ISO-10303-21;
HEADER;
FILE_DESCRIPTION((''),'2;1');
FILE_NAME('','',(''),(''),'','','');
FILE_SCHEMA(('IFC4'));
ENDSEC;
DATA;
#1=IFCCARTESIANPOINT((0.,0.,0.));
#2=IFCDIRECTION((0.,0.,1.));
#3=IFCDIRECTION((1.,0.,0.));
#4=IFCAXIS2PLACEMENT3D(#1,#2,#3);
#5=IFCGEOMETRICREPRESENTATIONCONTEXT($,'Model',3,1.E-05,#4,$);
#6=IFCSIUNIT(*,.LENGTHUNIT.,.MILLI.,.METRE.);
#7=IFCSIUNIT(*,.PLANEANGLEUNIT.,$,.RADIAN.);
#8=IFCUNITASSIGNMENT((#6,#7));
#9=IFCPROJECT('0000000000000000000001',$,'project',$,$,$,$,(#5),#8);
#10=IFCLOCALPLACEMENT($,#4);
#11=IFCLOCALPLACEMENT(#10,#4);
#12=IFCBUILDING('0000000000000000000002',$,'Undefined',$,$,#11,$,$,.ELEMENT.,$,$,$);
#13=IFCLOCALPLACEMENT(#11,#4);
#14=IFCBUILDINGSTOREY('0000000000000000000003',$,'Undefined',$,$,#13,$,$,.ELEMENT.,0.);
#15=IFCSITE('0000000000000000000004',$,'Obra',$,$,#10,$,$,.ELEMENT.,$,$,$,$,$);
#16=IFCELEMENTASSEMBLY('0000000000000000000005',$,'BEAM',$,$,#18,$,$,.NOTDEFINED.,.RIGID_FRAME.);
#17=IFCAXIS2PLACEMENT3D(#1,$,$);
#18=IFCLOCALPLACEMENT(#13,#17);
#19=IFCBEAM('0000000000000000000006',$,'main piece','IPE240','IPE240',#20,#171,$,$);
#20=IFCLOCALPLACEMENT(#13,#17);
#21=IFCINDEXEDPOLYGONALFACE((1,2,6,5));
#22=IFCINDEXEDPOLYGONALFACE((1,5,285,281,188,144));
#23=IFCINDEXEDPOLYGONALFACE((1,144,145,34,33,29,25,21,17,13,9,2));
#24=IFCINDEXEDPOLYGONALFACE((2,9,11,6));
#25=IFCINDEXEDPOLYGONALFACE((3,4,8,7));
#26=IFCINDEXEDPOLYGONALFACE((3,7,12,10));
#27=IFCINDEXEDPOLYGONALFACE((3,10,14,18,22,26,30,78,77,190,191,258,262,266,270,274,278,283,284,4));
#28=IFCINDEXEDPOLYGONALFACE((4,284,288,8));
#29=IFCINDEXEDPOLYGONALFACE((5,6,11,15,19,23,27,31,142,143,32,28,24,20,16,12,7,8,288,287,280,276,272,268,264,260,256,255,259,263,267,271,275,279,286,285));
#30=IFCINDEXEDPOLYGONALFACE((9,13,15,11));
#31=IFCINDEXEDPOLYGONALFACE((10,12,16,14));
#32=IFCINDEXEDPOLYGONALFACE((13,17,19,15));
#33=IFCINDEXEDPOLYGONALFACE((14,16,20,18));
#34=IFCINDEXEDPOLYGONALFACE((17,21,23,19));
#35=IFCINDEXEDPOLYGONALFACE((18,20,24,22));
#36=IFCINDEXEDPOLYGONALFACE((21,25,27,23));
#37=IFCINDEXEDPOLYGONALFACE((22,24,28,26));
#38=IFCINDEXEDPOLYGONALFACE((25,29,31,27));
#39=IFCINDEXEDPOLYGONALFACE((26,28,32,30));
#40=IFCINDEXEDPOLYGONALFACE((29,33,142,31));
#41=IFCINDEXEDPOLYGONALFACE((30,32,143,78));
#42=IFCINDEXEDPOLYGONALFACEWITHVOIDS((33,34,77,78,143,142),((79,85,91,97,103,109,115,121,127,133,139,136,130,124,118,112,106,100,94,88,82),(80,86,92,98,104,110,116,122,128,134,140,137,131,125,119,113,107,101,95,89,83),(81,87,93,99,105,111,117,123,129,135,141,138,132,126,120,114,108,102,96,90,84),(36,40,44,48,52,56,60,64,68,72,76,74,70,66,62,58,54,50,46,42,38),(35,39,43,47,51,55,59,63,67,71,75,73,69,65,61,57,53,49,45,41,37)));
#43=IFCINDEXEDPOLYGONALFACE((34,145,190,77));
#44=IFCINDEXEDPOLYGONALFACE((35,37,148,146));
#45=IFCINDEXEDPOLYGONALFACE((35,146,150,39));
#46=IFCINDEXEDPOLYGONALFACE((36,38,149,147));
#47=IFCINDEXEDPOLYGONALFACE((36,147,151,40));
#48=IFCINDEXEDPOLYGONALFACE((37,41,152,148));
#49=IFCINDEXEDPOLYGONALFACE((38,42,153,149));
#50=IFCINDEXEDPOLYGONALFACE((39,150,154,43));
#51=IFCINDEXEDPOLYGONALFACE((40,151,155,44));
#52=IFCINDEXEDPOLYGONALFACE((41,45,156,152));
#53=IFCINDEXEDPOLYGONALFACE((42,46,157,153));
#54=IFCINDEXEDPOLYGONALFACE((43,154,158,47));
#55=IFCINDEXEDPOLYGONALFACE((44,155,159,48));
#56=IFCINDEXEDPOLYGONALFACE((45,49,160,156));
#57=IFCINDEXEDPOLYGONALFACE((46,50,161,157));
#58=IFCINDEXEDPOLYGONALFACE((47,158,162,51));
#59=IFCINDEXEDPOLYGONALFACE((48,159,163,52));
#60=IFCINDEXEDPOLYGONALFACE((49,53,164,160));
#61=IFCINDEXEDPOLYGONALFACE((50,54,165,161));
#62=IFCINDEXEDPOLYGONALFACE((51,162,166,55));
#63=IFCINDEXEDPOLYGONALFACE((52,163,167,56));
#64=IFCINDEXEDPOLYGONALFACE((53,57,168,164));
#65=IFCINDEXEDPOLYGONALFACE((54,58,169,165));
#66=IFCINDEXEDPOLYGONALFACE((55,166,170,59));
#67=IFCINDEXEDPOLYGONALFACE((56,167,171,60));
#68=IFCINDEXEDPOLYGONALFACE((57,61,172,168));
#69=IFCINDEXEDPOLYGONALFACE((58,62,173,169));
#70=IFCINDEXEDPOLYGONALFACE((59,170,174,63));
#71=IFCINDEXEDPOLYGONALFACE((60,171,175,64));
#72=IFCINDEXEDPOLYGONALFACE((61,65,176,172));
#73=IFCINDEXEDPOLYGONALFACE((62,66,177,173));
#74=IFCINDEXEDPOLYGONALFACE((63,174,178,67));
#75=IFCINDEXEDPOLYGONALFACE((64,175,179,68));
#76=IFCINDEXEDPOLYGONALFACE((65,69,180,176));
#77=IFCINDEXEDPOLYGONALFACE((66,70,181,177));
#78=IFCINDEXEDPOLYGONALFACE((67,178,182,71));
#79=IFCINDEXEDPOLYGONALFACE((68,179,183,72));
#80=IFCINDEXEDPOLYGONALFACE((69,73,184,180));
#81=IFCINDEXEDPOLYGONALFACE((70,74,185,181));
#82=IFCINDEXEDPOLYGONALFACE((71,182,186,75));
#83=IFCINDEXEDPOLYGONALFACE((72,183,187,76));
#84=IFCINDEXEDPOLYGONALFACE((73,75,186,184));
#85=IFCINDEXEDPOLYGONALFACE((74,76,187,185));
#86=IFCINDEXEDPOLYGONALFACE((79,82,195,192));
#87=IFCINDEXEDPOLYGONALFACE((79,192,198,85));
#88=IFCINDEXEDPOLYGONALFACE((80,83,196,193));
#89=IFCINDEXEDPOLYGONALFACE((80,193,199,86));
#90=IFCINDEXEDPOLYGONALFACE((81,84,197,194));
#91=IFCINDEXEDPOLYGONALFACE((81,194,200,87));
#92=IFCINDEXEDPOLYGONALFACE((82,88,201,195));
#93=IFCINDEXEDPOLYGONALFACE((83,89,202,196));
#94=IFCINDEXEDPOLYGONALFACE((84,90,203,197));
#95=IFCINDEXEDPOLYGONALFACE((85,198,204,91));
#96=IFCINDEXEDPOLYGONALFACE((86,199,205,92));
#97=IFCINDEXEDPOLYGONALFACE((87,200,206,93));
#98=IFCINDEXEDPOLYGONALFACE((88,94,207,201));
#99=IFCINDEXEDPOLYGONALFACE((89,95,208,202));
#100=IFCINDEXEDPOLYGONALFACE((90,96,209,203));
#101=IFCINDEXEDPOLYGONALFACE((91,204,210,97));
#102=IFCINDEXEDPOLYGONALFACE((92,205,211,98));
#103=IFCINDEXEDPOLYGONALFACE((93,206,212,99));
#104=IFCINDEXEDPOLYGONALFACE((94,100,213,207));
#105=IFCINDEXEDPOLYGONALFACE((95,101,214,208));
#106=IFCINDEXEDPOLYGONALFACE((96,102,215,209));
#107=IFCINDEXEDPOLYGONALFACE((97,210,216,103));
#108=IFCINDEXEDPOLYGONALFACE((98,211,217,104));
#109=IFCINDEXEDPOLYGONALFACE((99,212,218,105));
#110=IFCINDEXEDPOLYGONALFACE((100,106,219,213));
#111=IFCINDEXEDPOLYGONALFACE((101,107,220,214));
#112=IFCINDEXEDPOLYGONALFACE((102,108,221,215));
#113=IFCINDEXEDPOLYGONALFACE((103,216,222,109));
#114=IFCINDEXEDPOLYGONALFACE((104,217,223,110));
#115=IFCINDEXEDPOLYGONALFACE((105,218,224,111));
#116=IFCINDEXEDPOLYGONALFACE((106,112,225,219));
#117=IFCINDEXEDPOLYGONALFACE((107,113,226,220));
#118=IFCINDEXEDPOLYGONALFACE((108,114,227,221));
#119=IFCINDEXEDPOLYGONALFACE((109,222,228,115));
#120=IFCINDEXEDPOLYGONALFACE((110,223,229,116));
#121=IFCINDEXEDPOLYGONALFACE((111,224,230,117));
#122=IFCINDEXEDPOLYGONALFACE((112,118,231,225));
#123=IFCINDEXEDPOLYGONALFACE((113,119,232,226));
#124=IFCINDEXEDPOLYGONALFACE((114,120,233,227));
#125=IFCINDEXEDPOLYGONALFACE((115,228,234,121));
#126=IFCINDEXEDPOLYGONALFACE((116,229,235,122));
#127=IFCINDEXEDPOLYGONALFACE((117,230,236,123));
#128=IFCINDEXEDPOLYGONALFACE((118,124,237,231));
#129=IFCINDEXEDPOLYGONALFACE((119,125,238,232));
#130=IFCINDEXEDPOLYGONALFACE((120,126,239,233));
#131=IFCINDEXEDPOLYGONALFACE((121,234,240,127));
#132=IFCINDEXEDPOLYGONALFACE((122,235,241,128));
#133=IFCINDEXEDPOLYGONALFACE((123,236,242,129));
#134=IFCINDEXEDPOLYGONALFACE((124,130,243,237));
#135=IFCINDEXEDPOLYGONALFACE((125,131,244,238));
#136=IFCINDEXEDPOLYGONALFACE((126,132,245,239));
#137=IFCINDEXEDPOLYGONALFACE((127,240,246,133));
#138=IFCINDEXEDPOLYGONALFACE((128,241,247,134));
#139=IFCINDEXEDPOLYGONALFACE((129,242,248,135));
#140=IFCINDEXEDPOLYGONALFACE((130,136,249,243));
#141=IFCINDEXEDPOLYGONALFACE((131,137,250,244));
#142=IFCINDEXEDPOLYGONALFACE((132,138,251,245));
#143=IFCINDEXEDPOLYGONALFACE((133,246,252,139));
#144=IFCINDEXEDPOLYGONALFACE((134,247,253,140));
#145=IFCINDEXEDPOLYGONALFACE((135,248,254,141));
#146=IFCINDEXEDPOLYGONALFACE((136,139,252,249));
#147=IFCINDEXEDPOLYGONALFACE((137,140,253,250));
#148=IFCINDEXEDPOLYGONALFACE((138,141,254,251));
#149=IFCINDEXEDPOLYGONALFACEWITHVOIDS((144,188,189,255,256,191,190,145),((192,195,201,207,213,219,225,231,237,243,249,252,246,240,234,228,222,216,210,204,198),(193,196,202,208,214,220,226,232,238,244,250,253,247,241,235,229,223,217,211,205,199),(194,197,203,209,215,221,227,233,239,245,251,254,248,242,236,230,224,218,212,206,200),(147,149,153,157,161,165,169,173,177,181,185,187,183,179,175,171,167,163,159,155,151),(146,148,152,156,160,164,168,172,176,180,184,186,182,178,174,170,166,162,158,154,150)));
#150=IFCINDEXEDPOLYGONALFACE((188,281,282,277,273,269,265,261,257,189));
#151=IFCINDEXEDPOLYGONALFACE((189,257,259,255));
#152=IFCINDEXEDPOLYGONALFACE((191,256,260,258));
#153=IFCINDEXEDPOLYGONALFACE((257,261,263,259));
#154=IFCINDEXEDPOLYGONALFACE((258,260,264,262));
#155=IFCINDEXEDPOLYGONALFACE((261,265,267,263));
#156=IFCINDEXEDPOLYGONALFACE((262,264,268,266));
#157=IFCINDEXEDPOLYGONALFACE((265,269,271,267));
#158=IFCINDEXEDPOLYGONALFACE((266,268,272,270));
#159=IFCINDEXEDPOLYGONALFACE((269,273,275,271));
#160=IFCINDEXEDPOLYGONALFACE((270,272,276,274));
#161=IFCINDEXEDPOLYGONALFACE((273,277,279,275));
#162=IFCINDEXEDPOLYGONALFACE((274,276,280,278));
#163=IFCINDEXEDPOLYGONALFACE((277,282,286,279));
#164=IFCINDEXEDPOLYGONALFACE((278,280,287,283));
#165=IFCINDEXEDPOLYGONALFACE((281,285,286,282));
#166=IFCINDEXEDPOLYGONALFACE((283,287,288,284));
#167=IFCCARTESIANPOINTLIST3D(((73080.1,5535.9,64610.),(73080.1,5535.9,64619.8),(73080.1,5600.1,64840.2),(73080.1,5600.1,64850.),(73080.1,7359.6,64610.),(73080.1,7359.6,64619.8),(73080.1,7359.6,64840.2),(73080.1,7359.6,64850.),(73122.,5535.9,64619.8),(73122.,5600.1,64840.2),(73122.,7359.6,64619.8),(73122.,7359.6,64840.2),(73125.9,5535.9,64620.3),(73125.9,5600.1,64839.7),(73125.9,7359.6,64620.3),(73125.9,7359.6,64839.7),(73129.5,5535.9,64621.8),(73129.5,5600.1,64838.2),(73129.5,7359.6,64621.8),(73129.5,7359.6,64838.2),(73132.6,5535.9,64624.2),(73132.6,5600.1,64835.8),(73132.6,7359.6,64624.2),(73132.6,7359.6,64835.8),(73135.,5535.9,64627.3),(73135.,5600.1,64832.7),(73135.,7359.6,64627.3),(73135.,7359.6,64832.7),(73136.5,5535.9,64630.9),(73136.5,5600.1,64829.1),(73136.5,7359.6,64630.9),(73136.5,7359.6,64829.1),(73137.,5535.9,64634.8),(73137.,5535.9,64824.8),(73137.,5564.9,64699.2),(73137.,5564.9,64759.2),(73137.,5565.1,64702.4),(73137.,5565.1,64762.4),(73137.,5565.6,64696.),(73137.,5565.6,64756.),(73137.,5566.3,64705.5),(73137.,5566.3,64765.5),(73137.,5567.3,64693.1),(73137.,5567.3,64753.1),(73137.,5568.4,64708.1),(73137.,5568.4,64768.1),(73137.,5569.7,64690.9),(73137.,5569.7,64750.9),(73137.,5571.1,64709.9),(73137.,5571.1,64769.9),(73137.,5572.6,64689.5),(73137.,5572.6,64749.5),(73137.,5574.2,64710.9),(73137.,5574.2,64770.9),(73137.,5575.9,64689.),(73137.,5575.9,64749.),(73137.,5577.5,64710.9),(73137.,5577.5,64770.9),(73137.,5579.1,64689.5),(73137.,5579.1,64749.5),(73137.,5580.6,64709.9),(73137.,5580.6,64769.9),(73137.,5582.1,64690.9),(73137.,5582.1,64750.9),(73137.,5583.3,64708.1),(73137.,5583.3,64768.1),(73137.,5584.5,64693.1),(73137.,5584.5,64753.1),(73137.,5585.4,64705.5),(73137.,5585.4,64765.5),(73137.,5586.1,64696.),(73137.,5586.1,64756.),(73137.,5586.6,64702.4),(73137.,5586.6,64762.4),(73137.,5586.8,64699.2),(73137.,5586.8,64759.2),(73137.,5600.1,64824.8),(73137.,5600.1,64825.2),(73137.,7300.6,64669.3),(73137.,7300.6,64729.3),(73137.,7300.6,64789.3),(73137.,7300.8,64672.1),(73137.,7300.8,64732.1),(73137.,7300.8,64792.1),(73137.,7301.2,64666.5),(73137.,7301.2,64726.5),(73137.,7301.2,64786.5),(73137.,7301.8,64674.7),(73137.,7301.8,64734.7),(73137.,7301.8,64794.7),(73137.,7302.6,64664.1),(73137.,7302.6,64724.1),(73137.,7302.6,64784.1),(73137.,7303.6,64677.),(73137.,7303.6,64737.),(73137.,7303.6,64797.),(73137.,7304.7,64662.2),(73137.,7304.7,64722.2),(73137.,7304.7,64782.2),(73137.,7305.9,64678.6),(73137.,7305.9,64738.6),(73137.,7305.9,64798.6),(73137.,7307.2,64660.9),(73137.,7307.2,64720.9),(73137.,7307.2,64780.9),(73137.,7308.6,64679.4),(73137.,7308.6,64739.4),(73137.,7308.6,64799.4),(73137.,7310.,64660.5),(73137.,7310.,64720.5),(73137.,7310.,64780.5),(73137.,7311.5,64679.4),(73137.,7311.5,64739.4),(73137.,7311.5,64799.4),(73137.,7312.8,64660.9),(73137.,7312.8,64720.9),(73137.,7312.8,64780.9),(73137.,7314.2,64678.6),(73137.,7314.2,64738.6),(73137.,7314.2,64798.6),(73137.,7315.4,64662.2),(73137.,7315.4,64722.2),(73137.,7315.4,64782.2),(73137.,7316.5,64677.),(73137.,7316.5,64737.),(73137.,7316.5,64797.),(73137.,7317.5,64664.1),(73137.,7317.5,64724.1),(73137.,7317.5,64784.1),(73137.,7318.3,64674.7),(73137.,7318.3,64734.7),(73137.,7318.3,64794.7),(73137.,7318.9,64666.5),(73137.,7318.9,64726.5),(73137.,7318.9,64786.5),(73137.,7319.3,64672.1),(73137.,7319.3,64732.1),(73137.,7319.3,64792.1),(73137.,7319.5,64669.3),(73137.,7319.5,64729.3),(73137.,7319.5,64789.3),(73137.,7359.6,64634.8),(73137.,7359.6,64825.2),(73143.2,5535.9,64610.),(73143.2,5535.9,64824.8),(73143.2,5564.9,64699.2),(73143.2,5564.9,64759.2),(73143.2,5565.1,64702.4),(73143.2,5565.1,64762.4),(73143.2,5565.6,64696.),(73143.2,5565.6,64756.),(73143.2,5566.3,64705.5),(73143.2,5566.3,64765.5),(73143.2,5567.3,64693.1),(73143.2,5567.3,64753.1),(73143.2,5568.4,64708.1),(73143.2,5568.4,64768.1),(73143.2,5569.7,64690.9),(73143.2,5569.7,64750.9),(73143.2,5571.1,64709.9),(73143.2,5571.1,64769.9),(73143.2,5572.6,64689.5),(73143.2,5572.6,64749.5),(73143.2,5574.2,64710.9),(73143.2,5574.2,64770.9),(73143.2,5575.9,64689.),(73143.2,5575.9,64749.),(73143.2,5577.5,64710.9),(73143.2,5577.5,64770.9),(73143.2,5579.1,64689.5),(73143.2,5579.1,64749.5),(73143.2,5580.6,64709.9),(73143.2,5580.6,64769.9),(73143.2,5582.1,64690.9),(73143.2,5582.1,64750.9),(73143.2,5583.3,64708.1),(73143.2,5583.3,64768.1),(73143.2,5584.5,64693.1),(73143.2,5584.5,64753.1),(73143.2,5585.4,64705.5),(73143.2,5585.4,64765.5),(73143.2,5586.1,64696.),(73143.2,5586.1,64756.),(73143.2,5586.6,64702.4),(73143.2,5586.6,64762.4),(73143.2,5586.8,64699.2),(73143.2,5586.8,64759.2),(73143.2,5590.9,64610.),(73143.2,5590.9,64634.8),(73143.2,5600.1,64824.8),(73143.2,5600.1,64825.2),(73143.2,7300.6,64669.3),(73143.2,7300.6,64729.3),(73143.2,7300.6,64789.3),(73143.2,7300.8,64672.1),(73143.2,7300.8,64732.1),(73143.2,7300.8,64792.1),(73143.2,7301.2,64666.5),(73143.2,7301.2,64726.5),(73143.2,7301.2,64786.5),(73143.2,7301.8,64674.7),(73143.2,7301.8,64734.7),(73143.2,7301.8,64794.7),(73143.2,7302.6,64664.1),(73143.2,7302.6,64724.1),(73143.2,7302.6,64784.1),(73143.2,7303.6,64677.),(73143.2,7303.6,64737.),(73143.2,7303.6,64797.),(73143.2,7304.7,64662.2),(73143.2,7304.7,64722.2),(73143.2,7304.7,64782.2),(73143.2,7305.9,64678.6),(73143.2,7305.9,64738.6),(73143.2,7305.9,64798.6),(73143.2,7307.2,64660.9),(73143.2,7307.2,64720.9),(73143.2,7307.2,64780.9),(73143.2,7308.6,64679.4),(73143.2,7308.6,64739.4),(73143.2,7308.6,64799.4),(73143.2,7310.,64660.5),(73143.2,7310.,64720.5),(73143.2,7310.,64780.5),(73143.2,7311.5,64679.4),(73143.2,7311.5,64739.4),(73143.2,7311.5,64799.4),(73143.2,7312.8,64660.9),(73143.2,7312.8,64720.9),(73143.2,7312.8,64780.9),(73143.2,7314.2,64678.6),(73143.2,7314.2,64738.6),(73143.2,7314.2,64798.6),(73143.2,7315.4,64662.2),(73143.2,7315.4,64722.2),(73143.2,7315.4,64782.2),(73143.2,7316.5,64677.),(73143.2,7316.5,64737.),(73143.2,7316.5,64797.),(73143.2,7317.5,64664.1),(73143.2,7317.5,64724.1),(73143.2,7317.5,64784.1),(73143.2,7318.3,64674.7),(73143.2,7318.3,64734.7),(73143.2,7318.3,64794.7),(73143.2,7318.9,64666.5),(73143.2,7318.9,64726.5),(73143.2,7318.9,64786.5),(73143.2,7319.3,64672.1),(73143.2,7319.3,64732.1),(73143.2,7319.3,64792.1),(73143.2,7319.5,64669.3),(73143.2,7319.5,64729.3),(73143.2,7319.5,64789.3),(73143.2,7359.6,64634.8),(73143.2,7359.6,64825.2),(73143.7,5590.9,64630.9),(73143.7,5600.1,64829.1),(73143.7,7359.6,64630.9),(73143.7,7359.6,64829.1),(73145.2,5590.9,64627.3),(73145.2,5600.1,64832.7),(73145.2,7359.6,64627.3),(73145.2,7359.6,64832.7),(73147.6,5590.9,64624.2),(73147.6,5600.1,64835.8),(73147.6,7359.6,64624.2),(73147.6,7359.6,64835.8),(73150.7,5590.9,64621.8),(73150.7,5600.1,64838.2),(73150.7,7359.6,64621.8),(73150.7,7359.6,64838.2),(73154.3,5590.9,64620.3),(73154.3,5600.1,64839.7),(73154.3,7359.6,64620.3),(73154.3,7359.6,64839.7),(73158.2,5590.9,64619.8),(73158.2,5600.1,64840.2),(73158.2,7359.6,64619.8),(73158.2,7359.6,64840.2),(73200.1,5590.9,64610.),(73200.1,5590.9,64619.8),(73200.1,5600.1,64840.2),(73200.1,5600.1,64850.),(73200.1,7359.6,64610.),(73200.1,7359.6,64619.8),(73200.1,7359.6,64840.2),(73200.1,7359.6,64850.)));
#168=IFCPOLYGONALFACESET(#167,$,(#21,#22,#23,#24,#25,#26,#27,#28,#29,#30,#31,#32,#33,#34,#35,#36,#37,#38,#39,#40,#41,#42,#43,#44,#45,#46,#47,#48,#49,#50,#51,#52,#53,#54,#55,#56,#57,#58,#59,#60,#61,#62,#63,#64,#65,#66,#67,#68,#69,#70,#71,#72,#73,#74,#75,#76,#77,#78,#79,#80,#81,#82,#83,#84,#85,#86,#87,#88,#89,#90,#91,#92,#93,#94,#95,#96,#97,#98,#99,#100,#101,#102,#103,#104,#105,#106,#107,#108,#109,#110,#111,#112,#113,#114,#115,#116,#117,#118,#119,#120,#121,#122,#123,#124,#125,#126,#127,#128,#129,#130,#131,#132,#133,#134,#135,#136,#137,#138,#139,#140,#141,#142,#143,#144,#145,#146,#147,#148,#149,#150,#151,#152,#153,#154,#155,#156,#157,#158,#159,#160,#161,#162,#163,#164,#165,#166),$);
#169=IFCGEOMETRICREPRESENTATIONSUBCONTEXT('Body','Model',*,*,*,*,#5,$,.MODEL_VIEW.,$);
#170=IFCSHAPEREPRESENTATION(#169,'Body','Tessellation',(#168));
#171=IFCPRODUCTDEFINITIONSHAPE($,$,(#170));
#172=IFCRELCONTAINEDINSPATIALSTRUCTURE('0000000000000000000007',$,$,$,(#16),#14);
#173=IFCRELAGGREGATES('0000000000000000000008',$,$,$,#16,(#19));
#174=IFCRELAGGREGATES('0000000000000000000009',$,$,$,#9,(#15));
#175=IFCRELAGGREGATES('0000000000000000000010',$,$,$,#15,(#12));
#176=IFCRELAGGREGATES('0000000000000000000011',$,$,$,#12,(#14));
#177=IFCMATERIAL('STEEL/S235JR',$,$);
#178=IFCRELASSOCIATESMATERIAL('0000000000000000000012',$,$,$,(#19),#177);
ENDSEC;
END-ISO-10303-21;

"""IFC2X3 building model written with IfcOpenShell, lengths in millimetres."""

from ifc_helpers import new_model, si_unit, frame, origin_with_axes, origin_2d_with_axis, place, context, subcontext, project, spatial, rectangle, circle, i_section, extrude, clip, halfspace, source, transform, mapped, material, element, aggregate, save


model = new_model("IFC2X3")

# Units and contexts
model_context = context("Model", 3, precision=1e-05, world=origin_with_axes())
body_context = subcontext(model_context, "Body", "Model", "MODEL_VIEW")
ifc_project = project(units=[si_unit("LENGTHUNIT", "METRE", prefix="MILLI"), si_unit("PLANEANGLEUNIT", "RADIAN")], contexts=[model_context])

# Site, building, storey
site_placement = place(None, origin_with_axes())
site = spatial("IfcSite", under=ifc_project, at=site_placement, Name="Obra", CompositionType="ELEMENT")
building_placement = place(site_placement, origin_with_axes())
building = spatial("IfcBuilding", under=site, at=building_placement, Name="Undefined", CompositionType="ELEMENT")
storey_placement = place(building_placement, origin_with_axes())
storey = spatial("IfcBuildingStorey", under=building, at=storey_placement, Name="Undefined", CompositionType="ELEMENT", Elevation=0.0)

# Element assembly, beam, openings
assembly_1_placement = place(storey_placement, origin_with_axes())
assembly_1 = element("IfcElementAssembly", 1, at=assembly_1_placement, inside=storey, Name="BEAM", AssemblyPlace="NOTDEFINED", PredefinedType="RIGID_FRAME")
ifc_material_1 = material(Name="STEEL/S235JR")
beam_1_placement = place(assembly_1_placement, frame((73140.1, 5602.8, 64730.0), z_axis=(0.0, 0.0, 1.0), x_axis=(0.0, 1.0, 0.0)))
beam_1 = element("IfcBeam", 2, at=beam_1_placement, material=ifc_material_1, Name="main piece", Description="IPE240", ObjectType="IPE240", context=body_context, shape_type="Clipping", body=[
    clip(clip(extrude(i_section(OverallWidth=120.0, OverallDepth=240.0, WebThickness=6.2, FlangeThickness=9.8, FilletRadius=15.0, at=origin_2d_with_axis()), frame((1756.8, 0.0, 0.0), z_axis=(-1.0, 0.0, 0.0), x_axis=(0.0, -1.0, 0.0)), (0.0, 0.0, 1.0), 1823.7), halfspace(frame((1756.8, -60.0, -120.0), z_axis=(1.0, 0.0, 0.0), x_axis=(0.0, 0.0, 1.0)), False)), halfspace(frame((-66.9, 0.0, -220.0), z_axis=(1.0, 0.0, 0.0), x_axis=(0.0, -1.0, 0.0)), True)),
])
opening_1_placement = place(assembly_1_placement, frame((73140.1, 5602.8, 64730.0), z_axis=(0.0, 0.0, 1.0), x_axis=(0.0, 1.0, 0.0)))
element("IfcOpeningElement", 3, at=opening_1_placement, cuts=beam_1, ObjectType="Recess", context=body_context, shape_type="SweptSolid", body=[
    extrude(rectangle(XDim=65.0, YDim=300.0, at=origin_2d_with_axis()), frame((-44.4, -153.1, 109.8), z_axis=(0.0, 0.0, -1.0), x_axis=(1.0, 0.0, 0.0)), (0.0, 0.0, 1.0), 249.6),
])
opening_2_placement = place(assembly_1_placement, frame((73140.1, 5602.8, 64730.0), z_axis=(0.0, 0.0, 1.0), x_axis=(0.0, 1.0, 0.0)))
element("IfcOpeningElement", 4, at=opening_2_placement, cuts=beam_1, ObjectType="Recess", context=body_context, shape_type="SweptSolid", body=[
    extrude(rectangle(XDim=26.2, YDim=76.2, at=origin_2d_with_axis()), frame((-40.8, -61.0, 107.9), z_axis=(0.0, 1.0, 0.0), x_axis=(0.0, 0.0, -1.0)), (0.0, 0.0, 1.0), 122.0),
])
shared_shape_1 = source(origin_with_axes(), body_context, "Body", "SweptSolid", [
    extrude(circle(Radius=11.0, at=origin_2d_with_axis()), frame((0.0, -3.2, 0.0), z_axis=(0.0, 1.0, 0.0), x_axis=(1.0, 0.0, 0.0)), (0.0, 0.0, 1.0), 6.4),
])
opening_3_placement = place(assembly_1_placement, frame((73140.1, 5535.9, 64850.0), z_axis=(0.0, 1.0, 0.0), x_axis=(0.0, 0.0, -1.0)))
element("IfcOpeningElement", 5, at=opening_3_placement, cuts=beam_1, ObjectType="Opening", context=body_context, shape_type="MappedRepresentation", body=[
    mapped(shared_shape_1, transform((90.0, 0.0, 40.0))),
    mapped(shared_shape_1, transform((150.0, 0.0, 40.0))),
])
shared_shape_2 = source(origin_with_axes(), body_context, "Body", "SweptSolid", [
    extrude(circle(Radius=9.5, at=origin_2d_with_axis()), frame((0.0, -3.2, 0.0), z_axis=(0.0, 1.0, 0.0), x_axis=(1.0, 0.0, 0.0)), (0.0, 0.0, 1.0), 6.4),
])
opening_4_placement = place(assembly_1_placement, frame((73140.1, 7360.0, 64850.0), z_axis=(-0.000019, -1.0, 0.0), x_axis=(0.0, 0.0, -1.0)))
element("IfcOpeningElement", 6, at=opening_4_placement, cuts=beam_1, ObjectType="Opening", context=body_context, shape_type="MappedRepresentation", body=[
    mapped(shared_shape_2, transform((60.0, 0.0, 50.0))),
    mapped(shared_shape_2, transform((120.0, 0.0, 50.0))),
    mapped(shared_shape_2, transform((180.0, 0.0, 50.0))),
])
aggregate(assembly_1, [beam_1])

save(model, "model.ifc")
